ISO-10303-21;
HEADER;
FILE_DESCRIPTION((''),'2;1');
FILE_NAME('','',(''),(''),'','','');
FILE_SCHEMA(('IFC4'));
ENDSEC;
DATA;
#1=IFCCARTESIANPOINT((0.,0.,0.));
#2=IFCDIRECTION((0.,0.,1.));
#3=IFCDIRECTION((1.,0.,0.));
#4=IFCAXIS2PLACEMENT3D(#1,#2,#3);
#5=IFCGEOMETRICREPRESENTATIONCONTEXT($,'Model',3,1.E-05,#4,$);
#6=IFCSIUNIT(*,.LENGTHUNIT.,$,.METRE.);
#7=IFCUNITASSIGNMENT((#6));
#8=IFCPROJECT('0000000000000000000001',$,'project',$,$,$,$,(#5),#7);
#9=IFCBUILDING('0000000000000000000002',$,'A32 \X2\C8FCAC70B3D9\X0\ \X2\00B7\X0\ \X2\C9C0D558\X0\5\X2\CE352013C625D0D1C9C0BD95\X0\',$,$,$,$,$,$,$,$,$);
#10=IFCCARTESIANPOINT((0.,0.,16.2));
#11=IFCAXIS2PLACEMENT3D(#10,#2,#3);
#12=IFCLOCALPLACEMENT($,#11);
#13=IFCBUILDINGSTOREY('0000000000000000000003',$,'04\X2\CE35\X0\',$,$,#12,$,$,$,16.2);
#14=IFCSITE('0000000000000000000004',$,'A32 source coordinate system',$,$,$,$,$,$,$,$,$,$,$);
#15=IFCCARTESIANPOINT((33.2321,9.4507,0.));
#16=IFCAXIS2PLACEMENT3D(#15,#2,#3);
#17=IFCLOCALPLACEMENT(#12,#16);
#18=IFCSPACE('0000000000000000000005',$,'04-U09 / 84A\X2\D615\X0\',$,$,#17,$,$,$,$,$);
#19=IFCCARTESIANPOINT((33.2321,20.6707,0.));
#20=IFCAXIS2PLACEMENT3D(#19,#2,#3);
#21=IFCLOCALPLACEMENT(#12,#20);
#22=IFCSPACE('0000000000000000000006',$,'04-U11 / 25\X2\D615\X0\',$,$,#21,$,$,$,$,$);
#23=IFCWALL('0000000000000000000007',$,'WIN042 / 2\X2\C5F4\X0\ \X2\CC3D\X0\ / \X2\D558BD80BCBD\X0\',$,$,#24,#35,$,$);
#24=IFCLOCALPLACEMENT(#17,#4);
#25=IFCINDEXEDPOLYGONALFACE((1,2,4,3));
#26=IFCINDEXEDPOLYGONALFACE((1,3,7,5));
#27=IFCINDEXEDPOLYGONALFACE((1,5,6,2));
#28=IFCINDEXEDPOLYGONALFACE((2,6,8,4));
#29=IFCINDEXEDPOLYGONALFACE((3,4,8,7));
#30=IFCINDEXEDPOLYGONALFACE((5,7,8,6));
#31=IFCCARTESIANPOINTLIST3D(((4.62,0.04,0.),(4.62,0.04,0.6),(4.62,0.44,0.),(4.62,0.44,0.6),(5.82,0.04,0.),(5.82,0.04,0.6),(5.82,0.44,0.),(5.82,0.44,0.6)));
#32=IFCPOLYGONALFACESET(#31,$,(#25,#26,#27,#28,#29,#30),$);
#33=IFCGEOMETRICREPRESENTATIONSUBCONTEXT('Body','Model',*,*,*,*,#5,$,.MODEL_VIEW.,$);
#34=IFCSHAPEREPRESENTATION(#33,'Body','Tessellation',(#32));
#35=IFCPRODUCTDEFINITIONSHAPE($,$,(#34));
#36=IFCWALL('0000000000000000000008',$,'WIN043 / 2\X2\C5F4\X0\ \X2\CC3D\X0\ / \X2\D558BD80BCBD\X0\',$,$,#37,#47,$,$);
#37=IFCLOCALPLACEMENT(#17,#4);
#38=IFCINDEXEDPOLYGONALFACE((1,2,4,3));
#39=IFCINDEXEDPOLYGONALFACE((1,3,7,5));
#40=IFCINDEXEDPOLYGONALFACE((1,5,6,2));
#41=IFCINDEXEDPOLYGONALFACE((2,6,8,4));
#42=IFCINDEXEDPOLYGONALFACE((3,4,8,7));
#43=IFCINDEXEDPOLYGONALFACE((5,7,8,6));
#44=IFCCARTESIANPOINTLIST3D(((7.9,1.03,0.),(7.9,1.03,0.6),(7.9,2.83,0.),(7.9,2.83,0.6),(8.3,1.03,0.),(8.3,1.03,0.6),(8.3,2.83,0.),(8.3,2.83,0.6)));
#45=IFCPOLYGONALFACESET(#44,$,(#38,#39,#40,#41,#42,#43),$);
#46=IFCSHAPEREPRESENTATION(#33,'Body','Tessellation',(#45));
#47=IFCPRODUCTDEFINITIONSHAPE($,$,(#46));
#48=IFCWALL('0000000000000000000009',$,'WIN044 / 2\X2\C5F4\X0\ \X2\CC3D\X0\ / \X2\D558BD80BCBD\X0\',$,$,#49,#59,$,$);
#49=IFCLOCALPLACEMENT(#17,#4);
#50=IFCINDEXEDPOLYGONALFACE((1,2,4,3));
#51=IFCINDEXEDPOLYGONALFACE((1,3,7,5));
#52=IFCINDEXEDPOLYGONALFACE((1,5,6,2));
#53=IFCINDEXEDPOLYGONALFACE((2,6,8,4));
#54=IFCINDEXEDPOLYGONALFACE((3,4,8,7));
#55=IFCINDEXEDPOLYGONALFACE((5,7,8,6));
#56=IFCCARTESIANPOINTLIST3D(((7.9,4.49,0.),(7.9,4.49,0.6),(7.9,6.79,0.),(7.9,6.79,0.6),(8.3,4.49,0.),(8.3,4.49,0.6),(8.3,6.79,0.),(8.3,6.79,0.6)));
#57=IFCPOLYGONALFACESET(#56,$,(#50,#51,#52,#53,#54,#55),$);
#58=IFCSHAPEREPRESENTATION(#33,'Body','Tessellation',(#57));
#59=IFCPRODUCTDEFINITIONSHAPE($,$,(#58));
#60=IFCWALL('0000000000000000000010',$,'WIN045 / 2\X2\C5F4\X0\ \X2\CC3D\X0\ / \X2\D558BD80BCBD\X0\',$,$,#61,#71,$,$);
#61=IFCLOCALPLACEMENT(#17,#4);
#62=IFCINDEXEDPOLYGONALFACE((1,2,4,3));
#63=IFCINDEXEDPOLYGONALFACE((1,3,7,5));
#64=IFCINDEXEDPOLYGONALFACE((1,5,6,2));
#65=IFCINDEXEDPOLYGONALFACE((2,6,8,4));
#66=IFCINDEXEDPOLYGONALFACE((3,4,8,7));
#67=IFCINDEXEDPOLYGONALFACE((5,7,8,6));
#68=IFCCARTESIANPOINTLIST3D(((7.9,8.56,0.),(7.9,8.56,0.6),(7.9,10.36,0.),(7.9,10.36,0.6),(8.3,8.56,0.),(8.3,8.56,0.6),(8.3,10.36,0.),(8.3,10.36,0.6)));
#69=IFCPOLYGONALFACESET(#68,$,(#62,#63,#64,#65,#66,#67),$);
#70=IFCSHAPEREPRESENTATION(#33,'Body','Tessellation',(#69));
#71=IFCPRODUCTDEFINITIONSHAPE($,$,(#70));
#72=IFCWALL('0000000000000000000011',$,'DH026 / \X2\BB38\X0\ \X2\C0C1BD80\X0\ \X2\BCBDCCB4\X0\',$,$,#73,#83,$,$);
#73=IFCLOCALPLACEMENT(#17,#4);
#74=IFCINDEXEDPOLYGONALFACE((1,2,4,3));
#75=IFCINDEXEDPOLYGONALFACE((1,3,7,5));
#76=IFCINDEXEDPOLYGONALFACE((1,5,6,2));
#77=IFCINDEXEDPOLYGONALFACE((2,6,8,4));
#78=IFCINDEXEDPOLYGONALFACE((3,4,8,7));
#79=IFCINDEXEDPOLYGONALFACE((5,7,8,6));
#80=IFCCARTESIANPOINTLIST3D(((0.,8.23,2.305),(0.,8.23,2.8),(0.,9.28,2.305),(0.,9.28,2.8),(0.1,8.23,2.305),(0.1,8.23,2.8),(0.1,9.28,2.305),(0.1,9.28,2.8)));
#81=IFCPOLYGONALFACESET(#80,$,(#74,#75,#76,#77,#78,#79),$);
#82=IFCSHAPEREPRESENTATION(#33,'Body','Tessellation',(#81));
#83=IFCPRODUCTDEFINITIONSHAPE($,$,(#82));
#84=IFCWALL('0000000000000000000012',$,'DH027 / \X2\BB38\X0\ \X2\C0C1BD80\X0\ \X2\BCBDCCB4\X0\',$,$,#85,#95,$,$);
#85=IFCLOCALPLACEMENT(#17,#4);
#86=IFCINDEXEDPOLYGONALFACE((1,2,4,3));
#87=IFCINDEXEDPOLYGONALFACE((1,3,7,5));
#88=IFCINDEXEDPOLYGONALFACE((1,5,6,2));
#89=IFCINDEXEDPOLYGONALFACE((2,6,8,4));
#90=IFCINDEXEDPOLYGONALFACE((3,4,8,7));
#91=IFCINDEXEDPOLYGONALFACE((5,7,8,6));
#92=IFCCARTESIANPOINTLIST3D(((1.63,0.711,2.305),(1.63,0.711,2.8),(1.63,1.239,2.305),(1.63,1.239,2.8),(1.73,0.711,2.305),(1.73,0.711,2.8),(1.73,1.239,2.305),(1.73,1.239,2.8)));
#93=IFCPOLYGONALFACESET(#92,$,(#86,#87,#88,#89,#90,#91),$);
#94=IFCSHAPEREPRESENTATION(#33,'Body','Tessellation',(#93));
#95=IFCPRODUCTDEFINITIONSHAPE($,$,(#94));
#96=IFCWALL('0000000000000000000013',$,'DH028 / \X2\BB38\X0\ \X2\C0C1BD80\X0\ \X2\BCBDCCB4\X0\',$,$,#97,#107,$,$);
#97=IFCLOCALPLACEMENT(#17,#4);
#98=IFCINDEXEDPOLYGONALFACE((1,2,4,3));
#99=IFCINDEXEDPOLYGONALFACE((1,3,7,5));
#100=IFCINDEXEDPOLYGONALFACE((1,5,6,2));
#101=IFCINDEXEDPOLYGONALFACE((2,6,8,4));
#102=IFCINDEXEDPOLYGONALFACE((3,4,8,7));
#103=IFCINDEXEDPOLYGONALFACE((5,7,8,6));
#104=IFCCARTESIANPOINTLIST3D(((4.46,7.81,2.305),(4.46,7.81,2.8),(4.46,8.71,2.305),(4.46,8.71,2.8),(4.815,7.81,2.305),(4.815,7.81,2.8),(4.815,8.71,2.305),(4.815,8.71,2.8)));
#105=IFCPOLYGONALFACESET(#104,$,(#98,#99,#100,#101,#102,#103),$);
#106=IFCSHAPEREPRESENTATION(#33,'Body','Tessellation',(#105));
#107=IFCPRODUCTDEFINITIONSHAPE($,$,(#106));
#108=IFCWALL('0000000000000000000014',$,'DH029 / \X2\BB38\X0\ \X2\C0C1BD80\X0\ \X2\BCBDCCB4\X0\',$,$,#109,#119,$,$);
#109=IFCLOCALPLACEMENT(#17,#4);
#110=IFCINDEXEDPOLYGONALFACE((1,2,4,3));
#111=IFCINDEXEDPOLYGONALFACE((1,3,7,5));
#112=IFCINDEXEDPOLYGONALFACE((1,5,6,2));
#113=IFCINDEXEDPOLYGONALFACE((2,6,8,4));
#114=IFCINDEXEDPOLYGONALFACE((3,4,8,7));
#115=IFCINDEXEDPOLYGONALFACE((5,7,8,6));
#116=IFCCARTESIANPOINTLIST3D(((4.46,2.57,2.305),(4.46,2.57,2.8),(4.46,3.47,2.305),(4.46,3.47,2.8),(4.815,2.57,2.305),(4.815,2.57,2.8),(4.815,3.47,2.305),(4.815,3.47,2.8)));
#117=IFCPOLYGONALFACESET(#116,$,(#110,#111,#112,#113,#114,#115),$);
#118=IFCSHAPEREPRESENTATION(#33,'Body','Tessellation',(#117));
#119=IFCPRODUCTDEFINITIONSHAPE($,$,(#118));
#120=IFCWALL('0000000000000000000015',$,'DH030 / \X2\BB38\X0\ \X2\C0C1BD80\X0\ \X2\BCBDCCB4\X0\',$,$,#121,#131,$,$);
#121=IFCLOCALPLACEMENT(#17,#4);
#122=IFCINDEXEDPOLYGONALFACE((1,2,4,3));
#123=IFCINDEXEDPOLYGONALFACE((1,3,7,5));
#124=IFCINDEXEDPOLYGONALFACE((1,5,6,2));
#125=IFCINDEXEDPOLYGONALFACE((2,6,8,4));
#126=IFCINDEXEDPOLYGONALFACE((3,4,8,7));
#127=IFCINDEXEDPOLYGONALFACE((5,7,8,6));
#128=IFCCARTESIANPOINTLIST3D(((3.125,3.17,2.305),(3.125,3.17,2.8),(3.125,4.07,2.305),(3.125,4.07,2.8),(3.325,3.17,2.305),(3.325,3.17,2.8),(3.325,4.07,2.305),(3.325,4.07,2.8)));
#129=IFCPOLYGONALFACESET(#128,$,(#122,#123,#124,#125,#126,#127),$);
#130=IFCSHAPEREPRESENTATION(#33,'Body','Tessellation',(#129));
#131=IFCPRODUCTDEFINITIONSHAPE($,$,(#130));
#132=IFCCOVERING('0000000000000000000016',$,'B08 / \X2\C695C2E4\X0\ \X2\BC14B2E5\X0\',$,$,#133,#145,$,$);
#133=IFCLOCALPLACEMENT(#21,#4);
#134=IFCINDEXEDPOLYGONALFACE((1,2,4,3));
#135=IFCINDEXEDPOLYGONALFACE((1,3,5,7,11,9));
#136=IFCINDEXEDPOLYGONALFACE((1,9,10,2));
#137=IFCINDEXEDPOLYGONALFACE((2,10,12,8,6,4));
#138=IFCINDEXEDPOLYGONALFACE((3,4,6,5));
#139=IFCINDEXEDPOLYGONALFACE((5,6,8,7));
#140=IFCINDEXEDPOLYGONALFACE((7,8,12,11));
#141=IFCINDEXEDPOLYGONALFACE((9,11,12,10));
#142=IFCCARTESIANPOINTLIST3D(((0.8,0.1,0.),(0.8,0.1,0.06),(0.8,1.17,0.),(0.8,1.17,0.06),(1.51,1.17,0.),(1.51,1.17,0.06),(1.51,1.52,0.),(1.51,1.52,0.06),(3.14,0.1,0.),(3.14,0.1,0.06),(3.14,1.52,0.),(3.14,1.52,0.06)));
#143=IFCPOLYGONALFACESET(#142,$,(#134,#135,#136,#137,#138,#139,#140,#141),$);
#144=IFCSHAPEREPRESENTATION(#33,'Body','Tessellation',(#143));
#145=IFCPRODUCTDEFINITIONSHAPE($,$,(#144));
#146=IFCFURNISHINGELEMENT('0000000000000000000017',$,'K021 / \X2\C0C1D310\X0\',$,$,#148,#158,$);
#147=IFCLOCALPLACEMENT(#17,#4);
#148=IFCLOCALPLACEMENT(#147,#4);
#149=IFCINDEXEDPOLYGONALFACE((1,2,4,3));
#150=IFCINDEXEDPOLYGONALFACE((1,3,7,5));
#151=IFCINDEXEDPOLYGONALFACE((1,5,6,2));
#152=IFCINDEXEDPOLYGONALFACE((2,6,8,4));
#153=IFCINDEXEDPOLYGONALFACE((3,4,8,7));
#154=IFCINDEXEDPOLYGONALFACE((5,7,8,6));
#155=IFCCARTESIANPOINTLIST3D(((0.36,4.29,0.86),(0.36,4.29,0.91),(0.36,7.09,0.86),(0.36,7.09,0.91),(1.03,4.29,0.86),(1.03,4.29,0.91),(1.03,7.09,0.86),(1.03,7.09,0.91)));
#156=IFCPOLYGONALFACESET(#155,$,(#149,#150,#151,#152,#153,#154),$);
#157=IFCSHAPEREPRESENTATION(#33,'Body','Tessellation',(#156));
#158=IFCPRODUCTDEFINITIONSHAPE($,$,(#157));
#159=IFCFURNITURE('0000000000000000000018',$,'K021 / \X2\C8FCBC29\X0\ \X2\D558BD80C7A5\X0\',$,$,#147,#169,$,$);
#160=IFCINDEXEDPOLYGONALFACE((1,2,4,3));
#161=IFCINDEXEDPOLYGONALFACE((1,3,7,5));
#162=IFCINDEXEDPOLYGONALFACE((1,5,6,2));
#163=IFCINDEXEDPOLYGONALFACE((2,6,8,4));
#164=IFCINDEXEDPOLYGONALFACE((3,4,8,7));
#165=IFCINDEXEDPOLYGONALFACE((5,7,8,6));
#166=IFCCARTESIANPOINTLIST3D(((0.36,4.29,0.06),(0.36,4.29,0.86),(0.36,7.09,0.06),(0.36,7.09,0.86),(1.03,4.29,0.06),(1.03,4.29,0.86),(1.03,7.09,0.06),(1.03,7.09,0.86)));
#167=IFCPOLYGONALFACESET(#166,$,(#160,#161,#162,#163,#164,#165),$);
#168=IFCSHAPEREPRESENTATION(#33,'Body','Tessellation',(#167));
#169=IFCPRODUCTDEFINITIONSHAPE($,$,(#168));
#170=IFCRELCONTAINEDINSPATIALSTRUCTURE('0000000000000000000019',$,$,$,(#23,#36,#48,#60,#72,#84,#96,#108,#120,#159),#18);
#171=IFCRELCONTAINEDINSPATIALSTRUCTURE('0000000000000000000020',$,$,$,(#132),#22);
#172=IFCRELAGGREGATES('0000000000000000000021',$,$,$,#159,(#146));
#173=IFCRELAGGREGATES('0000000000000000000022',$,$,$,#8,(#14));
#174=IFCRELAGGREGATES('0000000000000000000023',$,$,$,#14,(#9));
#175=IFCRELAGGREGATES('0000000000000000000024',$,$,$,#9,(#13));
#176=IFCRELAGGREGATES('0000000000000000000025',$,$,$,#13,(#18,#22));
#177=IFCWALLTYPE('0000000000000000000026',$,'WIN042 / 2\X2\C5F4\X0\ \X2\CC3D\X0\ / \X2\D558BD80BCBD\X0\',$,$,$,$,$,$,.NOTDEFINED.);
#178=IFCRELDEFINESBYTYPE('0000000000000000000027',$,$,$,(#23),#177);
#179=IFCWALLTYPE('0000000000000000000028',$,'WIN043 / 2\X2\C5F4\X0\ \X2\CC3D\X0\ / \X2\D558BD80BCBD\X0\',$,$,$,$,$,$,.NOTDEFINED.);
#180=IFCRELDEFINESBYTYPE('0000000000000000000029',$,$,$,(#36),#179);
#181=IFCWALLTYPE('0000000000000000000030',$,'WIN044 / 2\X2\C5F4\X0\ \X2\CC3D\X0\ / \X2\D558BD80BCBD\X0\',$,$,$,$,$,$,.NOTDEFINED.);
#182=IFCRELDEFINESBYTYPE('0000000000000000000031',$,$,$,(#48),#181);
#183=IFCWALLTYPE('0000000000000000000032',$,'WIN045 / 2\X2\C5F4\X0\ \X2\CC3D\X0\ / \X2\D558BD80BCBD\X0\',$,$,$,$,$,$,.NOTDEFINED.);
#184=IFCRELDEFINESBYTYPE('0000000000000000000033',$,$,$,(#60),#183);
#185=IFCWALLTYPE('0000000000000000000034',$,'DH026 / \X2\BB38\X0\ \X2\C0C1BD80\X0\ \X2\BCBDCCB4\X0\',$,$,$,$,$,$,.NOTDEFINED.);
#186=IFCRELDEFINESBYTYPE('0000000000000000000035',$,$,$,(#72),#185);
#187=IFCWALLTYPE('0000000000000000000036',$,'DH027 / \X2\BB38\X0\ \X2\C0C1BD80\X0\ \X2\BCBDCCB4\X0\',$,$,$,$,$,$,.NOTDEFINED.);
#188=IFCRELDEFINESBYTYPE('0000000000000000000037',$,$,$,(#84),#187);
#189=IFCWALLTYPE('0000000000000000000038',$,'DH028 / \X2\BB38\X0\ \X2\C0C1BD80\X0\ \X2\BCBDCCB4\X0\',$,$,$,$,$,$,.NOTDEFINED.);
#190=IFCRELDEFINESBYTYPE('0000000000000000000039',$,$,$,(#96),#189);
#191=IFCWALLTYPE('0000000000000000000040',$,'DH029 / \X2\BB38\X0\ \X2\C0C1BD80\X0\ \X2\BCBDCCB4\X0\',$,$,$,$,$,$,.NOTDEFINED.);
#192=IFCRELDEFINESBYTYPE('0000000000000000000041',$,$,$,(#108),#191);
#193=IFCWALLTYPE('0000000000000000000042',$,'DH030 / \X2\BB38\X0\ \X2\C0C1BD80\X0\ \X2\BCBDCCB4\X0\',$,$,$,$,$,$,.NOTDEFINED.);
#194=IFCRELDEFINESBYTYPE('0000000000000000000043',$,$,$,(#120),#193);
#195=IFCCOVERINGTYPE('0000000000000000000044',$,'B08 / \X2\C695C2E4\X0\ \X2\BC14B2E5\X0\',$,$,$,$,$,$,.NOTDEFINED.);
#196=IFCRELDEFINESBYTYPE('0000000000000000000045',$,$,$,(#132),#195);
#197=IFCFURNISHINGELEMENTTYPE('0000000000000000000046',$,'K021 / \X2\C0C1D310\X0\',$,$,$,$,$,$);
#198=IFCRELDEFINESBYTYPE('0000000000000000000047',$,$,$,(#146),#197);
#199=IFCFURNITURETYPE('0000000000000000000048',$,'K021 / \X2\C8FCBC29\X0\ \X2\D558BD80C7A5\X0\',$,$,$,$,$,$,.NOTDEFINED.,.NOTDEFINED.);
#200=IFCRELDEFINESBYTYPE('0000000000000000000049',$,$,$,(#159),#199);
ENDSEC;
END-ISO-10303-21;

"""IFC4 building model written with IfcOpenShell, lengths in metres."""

from ifc_helpers import new_model, si_unit, frame, origin, origin_with_axes, place, context, subcontext, project, spatial, polyline, outline, extrude, source, transform, mapped, type_object, type_shapes, element, aggregate, save


model = new_model("IFC4")

# Units and contexts
model_context = context("Model", 3, precision=1e-05, world=origin_with_axes())
body_context = subcontext(model_context, "Body", "Model", "MODEL_VIEW")
ifc_project = project(units=[si_unit("LENGTHUNIT", "METRE")], contexts=[model_context])

# Site, building, storey, space
site = spatial("IfcSite", under=ifc_project, Name="A32 source coordinate system")
building = spatial("IfcBuilding", under=site, Name="A32 주거동 · 지하5층–옥탑지붕")
storey_placement = place(None, frame((0.0, 0.0, 16.2), z_axis=(0.0, 0.0, 1.0), x_axis=(1.0, 0.0, 0.0)))
storey = spatial("IfcBuildingStorey", under=building, at=storey_placement, Name="04층", Elevation=16.2)
space_1_placement = place(storey_placement, frame((33.2321, 9.4507, 0.0), z_axis=(0.0, 0.0, 1.0), x_axis=(1.0, 0.0, 0.0)))
space_1 = spatial("IfcSpace", under=storey, at=space_1_placement, Name="04-U09 / 84A형")

# Walls
wall_type_1 = type_object("IfcWallType", Name="WIN042 / 2열 창 / 하부벽", PredefinedType="NOTDEFINED")
shared_shape_1 = source(origin(), body_context, "Body", "SweptSolid", [
    extrude(outline(polyline([(4.62, 0.44), (5.82, 0.44), (5.82, 0.04), (4.62, 0.04), (4.62, 0.44)])), origin(), (0.0, 0.0, 1.0), 0.6),
])
type_shapes(wall_type_1, [shared_shape_1])
wall_1_placement = place(space_1_placement, origin_with_axes())
element("IfcWall", 1, at=wall_1_placement, inside=space_1, type_object=wall_type_1, Name="WIN042 / 2열 창 / 하부벽", context=body_context, shape_type="MappedRepresentation", body=[
    mapped(shared_shape_1, transform((0.0, 0.0, 0.0), scale=1.0)),
])
wall_type_2 = type_object("IfcWallType", Name="WIN043 / 2열 창 / 하부벽", PredefinedType="NOTDEFINED")
shared_shape_2 = source(origin(), body_context, "Body", "SweptSolid", [
    extrude(outline(polyline([(7.9, 2.83), (8.3, 2.83), (8.3, 1.03), (7.9, 1.03), (7.9, 2.83)])), origin(), (0.0, 0.0, 1.0), 0.6),
])
type_shapes(wall_type_2, [shared_shape_2])
wall_2_placement = place(space_1_placement, origin_with_axes())
element("IfcWall", 2, at=wall_2_placement, inside=space_1, type_object=wall_type_2, Name="WIN043 / 2열 창 / 하부벽", context=body_context, shape_type="MappedRepresentation", body=[
    mapped(shared_shape_2, transform((0.0, 0.0, 0.0), scale=1.0)),
])
wall_type_3 = type_object("IfcWallType", Name="WIN044 / 2열 창 / 하부벽", PredefinedType="NOTDEFINED")
shared_shape_3 = source(origin(), body_context, "Body", "SweptSolid", [
    extrude(outline(polyline([(7.9, 6.79), (8.3, 6.79), (8.3, 4.49), (7.9, 4.49), (7.9, 6.79)])), origin(), (0.0, 0.0, 1.0), 0.6),
])
type_shapes(wall_type_3, [shared_shape_3])
wall_3_placement = place(space_1_placement, origin_with_axes())
element("IfcWall", 3, at=wall_3_placement, inside=space_1, type_object=wall_type_3, Name="WIN044 / 2열 창 / 하부벽", context=body_context, shape_type="MappedRepresentation", body=[
    mapped(shared_shape_3, transform((0.0, 0.0, 0.0), scale=1.0)),
])
wall_type_4 = type_object("IfcWallType", Name="WIN045 / 2열 창 / 하부벽", PredefinedType="NOTDEFINED")
shared_shape_4 = source(origin(), body_context, "Body", "SweptSolid", [
    extrude(outline(polyline([(7.9, 10.36), (8.3, 10.36), (8.3, 8.56), (7.9, 8.56), (7.9, 10.36)])), origin(), (0.0, 0.0, 1.0), 0.6),
])
type_shapes(wall_type_4, [shared_shape_4])
wall_4_placement = place(space_1_placement, origin_with_axes())
element("IfcWall", 4, at=wall_4_placement, inside=space_1, type_object=wall_type_4, Name="WIN045 / 2열 창 / 하부벽", context=body_context, shape_type="MappedRepresentation", body=[
    mapped(shared_shape_4, transform((0.0, 0.0, 0.0), scale=1.0)),
])
wall_type_5 = type_object("IfcWallType", Name="DH026 / 문 상부 벽체", PredefinedType="NOTDEFINED")
shared_shape_5 = source(origin(), body_context, "Body", "SweptSolid", [
    extrude(outline(polyline([(0.1, 9.28), (0.1, 8.23), (0.0, 8.23), (0.0, 9.28), (0.1, 9.28)])), frame((0.0, 0.0, 2.305)), (0.0, 0.0, 1.0), 0.495),
])
type_shapes(wall_type_5, [shared_shape_5])
wall_5_placement = place(space_1_placement, origin_with_axes())
element("IfcWall", 5, at=wall_5_placement, inside=space_1, type_object=wall_type_5, Name="DH026 / 문 상부 벽체", context=body_context, shape_type="MappedRepresentation", body=[
    mapped(shared_shape_5, transform((0.0, 0.0, 0.0), scale=1.0)),
])
wall_type_6 = type_object("IfcWallType", Name="DH027 / 문 상부 벽체", PredefinedType="NOTDEFINED")
shared_shape_6 = source(origin(), body_context, "Body", "SweptSolid", [
    extrude(outline(polyline([(1.63, 1.239), (1.73, 1.239), (1.73, 0.711), (1.63, 0.711), (1.63, 1.239)])), frame((0.0, 0.0, 2.305)), (0.0, 0.0, 1.0), 0.495),
])
type_shapes(wall_type_6, [shared_shape_6])
wall_6_placement = place(space_1_placement, origin_with_axes())
element("IfcWall", 6, at=wall_6_placement, inside=space_1, type_object=wall_type_6, Name="DH027 / 문 상부 벽체", context=body_context, shape_type="MappedRepresentation", body=[
    mapped(shared_shape_6, transform((0.0, 0.0, 0.0), scale=1.0)),
])
wall_type_7 = type_object("IfcWallType", Name="DH028 / 문 상부 벽체", PredefinedType="NOTDEFINED")
shared_shape_7 = source(origin(), body_context, "Body", "SweptSolid", [
    extrude(outline(polyline([(4.815, 8.71), (4.815, 7.81), (4.46, 7.81), (4.46, 8.71), (4.815, 8.71)])), frame((0.0, 0.0, 2.305)), (0.0, 0.0, 1.0), 0.495),
])
type_shapes(wall_type_7, [shared_shape_7])
wall_7_placement = place(space_1_placement, origin_with_axes())
element("IfcWall", 7, at=wall_7_placement, inside=space_1, type_object=wall_type_7, Name="DH028 / 문 상부 벽체", context=body_context, shape_type="MappedRepresentation", body=[
    mapped(shared_shape_7, transform((0.0, 0.0, 0.0), scale=1.0)),
])
wall_type_8 = type_object("IfcWallType", Name="DH029 / 문 상부 벽체", PredefinedType="NOTDEFINED")
shared_shape_8 = source(origin(), body_context, "Body", "SweptSolid", [
    extrude(outline(polyline([(4.815, 3.47), (4.815, 2.57), (4.46, 2.57), (4.46, 3.47), (4.815, 3.47)])), frame((0.0, 0.0, 2.305)), (0.0, 0.0, 1.0), 0.495),
])
type_shapes(wall_type_8, [shared_shape_8])
wall_8_placement = place(space_1_placement, origin_with_axes())
element("IfcWall", 8, at=wall_8_placement, inside=space_1, type_object=wall_type_8, Name="DH029 / 문 상부 벽체", context=body_context, shape_type="MappedRepresentation", body=[
    mapped(shared_shape_8, transform((0.0, 0.0, 0.0), scale=1.0)),
])
wall_type_9 = type_object("IfcWallType", Name="DH030 / 문 상부 벽체", PredefinedType="NOTDEFINED")
shared_shape_9 = source(origin(), body_context, "Body", "SweptSolid", [
    extrude(outline(polyline([(3.325, 4.07), (3.325, 3.17), (3.125, 3.17), (3.125, 4.07), (3.325, 4.07)])), frame((0.0, 0.0, 2.305)), (0.0, 0.0, 1.0), 0.495),
])
type_shapes(wall_type_9, [shared_shape_9])
wall_9_placement = place(space_1_placement, origin_with_axes())
element("IfcWall", 9, at=wall_9_placement, inside=space_1, type_object=wall_type_9, Name="DH030 / 문 상부 벽체", context=body_context, shape_type="MappedRepresentation", body=[
    mapped(shared_shape_9, transform((0.0, 0.0, 0.0), scale=1.0)),
])

# Shared definitions
space_2_placement = place(storey_placement, frame((33.2321, 20.6707, 0.0), z_axis=(0.0, 0.0, 1.0), x_axis=(1.0, 0.0, 0.0)))
space_2 = spatial("IfcSpace", under=storey, at=space_2_placement, Name="04-U11 / 25형")

# Covering
covering_type = type_object("IfcCoveringType", Name="B08 / 욕실 바닥", PredefinedType="NOTDEFINED")
shared_shape_10 = source(origin(), body_context, "Body", "SweptSolid", [
    extrude(outline(polyline([(3.14, 0.1), (0.8, 0.1), (0.8, 1.17), (1.51, 1.17), (1.51, 1.52), (3.14, 1.52), (3.14, 0.1)])), origin(), (0.0, 0.0, 1.0), 0.06),
])
type_shapes(covering_type, [shared_shape_10])
covering_placement = place(space_2_placement, origin_with_axes())
element("IfcCovering", 10, at=covering_placement, inside=space_2, type_object=covering_type, Name="B08 / 욕실 바닥", context=body_context, shape_type="MappedRepresentation", body=[
    mapped(shared_shape_10, transform((0.0, 0.0, 0.0), scale=1.0)),
])

# Furnishing element
furnishing_element_type = type_object("IfcFurnishingElementType", Name="K021 / 상판")
shared_shape_11 = source(origin(), body_context, "Body", "SweptSolid", [
    extrude(outline(polyline([(0.36, 7.09), (1.03, 7.09), (1.03, 4.29), (0.36, 4.29), (0.36, 7.09)])), frame((0.0, 0.0, 0.86)), (0.0, 0.0, 1.0), 0.05),
])
type_shapes(furnishing_element_type, [shared_shape_11])
furniture_placement = place(space_1_placement, origin_with_axes())
furnishing_placement = place(furniture_placement, origin_with_axes())
furnishing = element("IfcFurnishingElement", 11, at=furnishing_placement, type_object=furnishing_element_type, Name="K021 / 상판", context=body_context, shape_type="MappedRepresentation", body=[
    mapped(shared_shape_11, transform((0.0, 0.0, 0.0), scale=1.0)),
])

# Furniture
furniture_type = type_object("IfcFurnitureType", Name="K021 / 주방 하부장", AssemblyPlace="NOTDEFINED", PredefinedType="NOTDEFINED")
shared_shape_12 = source(origin(), body_context, "Body", "SweptSolid", [
    extrude(outline(polyline([(0.36, 4.29), (0.36, 7.09), (1.03, 7.09), (1.03, 4.29), (0.36, 4.29)])), frame((0.0, 0.0, 0.06)), (0.0, 0.0, 1.0), 0.8),
])
type_shapes(furniture_type, [shared_shape_12])
furniture = element("IfcFurniture", 12, at=furniture_placement, inside=space_1, type_object=furniture_type, Name="K021 / 주방 하부장", context=body_context, shape_type="MappedRepresentation", body=[
    mapped(shared_shape_12, transform((0.0, 0.0, 0.0), scale=1.0)),
])
aggregate(furniture, [furnishing])

save(model, "model.ifc")
